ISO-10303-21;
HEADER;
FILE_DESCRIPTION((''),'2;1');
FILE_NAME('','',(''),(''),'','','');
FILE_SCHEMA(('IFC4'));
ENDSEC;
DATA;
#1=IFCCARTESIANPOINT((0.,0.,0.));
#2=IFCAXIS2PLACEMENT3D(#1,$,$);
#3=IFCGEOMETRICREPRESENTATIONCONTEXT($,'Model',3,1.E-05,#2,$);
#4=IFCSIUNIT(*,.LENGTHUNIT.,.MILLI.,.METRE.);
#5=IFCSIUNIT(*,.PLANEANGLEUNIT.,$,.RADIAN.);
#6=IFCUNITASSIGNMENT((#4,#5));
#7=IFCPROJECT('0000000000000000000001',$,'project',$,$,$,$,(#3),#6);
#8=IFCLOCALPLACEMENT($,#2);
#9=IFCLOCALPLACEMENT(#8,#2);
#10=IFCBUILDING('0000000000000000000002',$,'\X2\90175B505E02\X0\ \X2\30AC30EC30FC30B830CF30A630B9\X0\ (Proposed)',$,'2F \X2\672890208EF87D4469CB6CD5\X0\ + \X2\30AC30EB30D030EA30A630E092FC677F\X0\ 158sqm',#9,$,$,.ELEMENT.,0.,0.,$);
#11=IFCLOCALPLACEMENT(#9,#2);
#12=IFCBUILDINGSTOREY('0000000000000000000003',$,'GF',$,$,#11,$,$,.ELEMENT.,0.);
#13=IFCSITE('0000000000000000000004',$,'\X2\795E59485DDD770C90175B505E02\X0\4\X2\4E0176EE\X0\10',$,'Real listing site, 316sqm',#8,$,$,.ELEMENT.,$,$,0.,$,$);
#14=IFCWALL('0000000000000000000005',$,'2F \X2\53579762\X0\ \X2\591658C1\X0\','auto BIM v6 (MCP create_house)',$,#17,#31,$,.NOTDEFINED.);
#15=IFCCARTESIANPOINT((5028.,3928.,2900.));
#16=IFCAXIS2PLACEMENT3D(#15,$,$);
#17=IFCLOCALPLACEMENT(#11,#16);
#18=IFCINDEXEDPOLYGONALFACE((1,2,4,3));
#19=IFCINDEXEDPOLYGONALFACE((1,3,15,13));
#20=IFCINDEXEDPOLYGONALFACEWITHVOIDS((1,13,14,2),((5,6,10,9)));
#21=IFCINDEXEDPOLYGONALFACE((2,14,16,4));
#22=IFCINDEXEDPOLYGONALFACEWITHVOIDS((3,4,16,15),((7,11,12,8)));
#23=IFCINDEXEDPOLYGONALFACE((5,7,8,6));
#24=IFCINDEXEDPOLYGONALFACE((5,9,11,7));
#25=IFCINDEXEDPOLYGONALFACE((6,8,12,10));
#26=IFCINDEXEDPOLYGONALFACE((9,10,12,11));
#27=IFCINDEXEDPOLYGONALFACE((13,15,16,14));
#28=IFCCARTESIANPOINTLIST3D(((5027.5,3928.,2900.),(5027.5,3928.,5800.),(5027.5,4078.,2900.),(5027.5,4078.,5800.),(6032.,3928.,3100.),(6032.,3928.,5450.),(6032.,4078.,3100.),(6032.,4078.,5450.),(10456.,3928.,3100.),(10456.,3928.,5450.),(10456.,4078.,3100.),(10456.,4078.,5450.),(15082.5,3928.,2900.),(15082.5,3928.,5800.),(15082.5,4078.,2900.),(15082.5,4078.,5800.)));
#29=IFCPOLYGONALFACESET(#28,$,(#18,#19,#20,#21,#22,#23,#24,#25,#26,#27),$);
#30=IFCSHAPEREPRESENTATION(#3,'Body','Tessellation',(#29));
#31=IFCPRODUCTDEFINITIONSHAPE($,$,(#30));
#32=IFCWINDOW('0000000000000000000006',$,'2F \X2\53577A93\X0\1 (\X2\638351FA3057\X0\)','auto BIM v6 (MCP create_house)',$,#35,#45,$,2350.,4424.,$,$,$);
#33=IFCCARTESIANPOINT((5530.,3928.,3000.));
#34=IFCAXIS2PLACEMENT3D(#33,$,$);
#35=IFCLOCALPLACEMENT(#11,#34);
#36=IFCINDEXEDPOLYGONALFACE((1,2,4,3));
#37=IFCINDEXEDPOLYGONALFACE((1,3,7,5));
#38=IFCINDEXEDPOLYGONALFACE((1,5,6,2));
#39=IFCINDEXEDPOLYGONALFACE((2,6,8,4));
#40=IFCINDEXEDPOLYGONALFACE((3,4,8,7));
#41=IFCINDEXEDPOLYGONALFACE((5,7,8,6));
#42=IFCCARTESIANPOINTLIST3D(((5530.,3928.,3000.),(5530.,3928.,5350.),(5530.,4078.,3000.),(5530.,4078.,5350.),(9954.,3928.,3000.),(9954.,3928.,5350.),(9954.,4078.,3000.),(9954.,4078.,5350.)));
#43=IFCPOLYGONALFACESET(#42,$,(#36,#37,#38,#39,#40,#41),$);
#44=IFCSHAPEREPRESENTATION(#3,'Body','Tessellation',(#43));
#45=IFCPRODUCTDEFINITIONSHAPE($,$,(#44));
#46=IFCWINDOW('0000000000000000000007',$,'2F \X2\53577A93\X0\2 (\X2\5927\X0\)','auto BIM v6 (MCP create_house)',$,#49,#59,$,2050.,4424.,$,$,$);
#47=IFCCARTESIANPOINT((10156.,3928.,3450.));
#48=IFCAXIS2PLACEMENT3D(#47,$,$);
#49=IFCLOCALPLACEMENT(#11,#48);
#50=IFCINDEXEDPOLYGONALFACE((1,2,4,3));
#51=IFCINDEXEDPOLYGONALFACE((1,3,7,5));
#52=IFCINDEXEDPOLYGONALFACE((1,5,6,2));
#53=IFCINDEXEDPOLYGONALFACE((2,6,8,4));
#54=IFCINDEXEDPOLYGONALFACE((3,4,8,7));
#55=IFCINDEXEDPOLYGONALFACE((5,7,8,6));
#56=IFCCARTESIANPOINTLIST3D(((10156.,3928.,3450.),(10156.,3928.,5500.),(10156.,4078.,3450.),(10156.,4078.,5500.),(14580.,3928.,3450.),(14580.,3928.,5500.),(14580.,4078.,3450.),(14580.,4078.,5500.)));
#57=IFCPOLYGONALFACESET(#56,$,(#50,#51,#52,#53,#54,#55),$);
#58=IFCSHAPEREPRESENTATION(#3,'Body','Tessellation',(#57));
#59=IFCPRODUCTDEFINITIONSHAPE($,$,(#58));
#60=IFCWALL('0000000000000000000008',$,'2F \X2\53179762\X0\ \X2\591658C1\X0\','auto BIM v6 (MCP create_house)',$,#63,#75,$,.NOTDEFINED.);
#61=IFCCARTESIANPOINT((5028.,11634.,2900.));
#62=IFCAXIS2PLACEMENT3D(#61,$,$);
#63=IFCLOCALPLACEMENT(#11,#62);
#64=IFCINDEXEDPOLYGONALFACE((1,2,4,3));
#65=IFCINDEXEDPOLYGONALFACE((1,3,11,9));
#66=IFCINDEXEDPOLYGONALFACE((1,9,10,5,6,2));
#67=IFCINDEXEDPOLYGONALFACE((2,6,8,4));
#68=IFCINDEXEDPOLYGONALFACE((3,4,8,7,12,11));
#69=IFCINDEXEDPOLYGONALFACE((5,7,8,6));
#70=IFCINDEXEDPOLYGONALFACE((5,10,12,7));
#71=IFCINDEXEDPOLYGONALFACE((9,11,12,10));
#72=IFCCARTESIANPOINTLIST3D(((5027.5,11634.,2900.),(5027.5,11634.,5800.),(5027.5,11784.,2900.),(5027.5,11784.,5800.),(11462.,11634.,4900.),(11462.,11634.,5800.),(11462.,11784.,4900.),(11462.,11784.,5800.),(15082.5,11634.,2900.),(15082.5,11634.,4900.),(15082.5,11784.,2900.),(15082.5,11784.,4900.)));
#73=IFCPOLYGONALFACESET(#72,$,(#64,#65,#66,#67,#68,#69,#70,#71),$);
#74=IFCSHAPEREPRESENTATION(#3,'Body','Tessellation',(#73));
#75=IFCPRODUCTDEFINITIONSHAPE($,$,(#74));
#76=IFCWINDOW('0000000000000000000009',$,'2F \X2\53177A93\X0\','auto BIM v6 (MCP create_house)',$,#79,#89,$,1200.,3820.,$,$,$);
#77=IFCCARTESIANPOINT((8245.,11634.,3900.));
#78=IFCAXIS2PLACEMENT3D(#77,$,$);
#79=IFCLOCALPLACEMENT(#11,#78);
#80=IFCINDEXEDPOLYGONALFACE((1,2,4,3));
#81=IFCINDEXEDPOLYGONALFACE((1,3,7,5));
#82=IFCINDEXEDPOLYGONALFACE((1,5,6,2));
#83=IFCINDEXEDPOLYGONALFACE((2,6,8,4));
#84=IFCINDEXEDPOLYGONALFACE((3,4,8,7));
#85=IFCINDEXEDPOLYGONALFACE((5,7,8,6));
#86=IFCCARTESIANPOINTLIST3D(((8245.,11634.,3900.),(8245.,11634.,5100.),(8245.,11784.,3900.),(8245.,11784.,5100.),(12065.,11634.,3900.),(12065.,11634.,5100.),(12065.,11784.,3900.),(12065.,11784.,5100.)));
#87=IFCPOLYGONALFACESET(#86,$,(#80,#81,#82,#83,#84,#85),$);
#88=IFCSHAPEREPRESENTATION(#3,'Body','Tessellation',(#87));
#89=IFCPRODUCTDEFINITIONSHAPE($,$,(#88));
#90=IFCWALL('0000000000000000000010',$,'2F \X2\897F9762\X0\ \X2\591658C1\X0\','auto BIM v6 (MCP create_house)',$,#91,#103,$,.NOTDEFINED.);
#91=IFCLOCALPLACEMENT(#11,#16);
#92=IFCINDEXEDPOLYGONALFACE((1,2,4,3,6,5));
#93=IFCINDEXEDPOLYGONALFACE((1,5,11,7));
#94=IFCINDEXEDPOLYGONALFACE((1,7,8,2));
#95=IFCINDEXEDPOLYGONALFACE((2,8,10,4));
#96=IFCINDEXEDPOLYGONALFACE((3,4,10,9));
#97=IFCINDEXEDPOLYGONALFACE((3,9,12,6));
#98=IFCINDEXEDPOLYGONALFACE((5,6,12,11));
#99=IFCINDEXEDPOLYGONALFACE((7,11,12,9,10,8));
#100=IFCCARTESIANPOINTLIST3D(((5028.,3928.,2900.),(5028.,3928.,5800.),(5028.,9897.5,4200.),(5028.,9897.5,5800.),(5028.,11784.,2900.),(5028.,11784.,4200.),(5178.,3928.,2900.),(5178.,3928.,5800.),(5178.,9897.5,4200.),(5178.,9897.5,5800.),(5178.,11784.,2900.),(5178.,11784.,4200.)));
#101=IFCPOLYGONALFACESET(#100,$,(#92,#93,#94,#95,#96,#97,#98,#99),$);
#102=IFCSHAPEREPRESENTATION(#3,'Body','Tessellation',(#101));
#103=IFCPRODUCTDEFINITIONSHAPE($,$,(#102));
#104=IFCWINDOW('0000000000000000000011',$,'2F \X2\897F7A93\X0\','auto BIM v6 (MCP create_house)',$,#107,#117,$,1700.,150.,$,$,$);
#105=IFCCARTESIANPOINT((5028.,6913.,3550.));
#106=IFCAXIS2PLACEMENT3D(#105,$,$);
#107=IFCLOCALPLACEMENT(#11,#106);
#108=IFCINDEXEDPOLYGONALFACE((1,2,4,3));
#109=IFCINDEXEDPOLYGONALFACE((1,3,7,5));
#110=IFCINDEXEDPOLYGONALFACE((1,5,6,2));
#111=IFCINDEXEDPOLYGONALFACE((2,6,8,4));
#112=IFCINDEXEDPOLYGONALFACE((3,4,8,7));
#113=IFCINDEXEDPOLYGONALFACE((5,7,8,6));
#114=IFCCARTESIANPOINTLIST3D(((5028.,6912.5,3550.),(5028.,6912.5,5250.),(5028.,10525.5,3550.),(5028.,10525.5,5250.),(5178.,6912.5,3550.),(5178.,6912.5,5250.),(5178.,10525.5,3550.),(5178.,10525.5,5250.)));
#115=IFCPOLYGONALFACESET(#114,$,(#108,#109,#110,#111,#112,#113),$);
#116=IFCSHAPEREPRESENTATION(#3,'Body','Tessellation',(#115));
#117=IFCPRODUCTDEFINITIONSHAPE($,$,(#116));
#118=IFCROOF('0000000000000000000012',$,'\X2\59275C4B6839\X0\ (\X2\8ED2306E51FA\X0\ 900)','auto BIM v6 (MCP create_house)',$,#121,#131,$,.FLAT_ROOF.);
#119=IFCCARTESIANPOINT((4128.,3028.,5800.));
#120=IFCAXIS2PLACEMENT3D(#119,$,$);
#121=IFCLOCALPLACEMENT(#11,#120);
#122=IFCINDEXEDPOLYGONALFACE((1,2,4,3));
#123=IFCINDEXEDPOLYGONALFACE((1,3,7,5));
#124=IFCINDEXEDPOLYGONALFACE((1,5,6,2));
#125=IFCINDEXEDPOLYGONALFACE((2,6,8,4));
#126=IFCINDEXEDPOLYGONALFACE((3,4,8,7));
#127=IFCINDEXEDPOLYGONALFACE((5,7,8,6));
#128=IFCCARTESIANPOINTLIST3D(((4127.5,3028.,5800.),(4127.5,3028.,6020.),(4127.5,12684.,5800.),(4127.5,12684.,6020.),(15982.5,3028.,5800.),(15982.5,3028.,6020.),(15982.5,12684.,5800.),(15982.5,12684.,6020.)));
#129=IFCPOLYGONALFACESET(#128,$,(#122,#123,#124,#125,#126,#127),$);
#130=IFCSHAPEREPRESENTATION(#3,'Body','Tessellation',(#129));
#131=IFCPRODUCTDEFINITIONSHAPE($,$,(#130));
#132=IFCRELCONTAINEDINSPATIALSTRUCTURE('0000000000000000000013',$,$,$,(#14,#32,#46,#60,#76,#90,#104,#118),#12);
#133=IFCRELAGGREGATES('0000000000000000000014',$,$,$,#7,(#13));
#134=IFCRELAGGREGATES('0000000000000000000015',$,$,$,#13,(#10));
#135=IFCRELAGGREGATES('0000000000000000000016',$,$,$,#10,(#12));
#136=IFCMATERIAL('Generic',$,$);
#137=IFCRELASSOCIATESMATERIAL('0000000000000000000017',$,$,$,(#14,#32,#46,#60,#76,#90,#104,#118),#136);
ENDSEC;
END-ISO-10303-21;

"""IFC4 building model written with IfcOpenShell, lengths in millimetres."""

from ifc_helpers import new_model, si_unit, frame, frame_2d, origin, place, context, project, spatial, rectangle, extrude, material, element, fill, save


model = new_model("IFC4")

# Units and contexts
model_context = context("Model", 3, precision=1e-05, world=origin())
ifc_project = project(units=[si_unit("LENGTHUNIT", "METRE", prefix="MILLI"), si_unit("PLANEANGLEUNIT", "RADIAN")], contexts=[model_context])

# Site, building, storey
site_placement = place(None, origin())
site = spatial("IfcSite", under=ifc_project, at=site_placement, Name="神奈川県逗子市4丁目10", ObjectType="Real listing site, 316sqm", CompositionType="ELEMENT", RefElevation=0.0)
building_placement = place(site_placement, origin())
building = spatial("IfcBuilding", under=site, at=building_placement, Name="逗子市 ガレージハウス (Proposed)", ObjectType="2F 木造軸組構法 + ガルバリウム鋼板 158sqm", CompositionType="ELEMENT", ElevationOfRefHeight=0.0, ElevationOfTerrain=0.0)
storey_placement = place(building_placement, origin())
storey = spatial("IfcBuildingStorey", under=building, at=storey_placement, Name="GF", CompositionType="ELEMENT", Elevation=0.0)

# Shared definitions
ifc_material = material(Name="Generic")

# Wall, openings, windows
wall_1_placement = place(storey_placement, frame((5028.0, 3928.0, 2900.0)))
wall_1 = element("IfcWall", 1, at=wall_1_placement, inside=storey, material=ifc_material, Name="2F 南面 外壁", Description="auto BIM v6 (MCP create_house)", PredefinedType="NOTDEFINED", context=model_context, shape_type="SweptSolid", body=[
    extrude(rectangle(XDim=10055.0, YDim=150.0, at=frame_2d((5027.0, 75.0))), frame((5028.0, 3928.0, 2900.0)), (0.0, 0.0, 1.0), 2900.0),
])
opening_1_placement = place(storey_placement, frame((5530.0, 3928.0, 3000.0)))
opening_1 = element("IfcOpeningElement", 2, at=opening_1_placement, cuts=wall_1, PredefinedType="NOTDEFINED", context=model_context, shape_type="SweptSolid", body=[
    extrude(rectangle(XDim=4424.0, YDim=150.0, at=frame_2d((2212.0, 75.0))), frame((5530.0, 3928.0, 3000.0)), (0.0, 0.0, 1.0), 2350.0),
])
opening_2_placement = place(storey_placement, frame((10156.0, 3928.0, 3450.0)))
opening_2 = element("IfcOpeningElement", 3, at=opening_2_placement, cuts=wall_1, PredefinedType="NOTDEFINED", context=model_context, shape_type="SweptSolid", body=[
    extrude(rectangle(XDim=4424.0, YDim=150.0, at=frame_2d((2212.0, 75.0))), frame((10156.0, 3928.0, 3450.0)), (0.0, 0.0, 1.0), 2050.0),
])
window_1_placement = place(storey_placement, frame((5530.0, 3928.0, 3000.0)))
window_1 = element("IfcWindow", 4, at=window_1_placement, inside=storey, material=ifc_material, Name="2F 南窓1 (掃出し)", Description="auto BIM v6 (MCP create_house)", OverallHeight=2350.0, OverallWidth=4424.0, context=model_context, shape_type="SweptSolid", body=[
    extrude(rectangle(XDim=4424.0, YDim=150.0, at=frame_2d((2212.0, 75.0))), frame((5530.0, 3928.0, 3000.0)), (0.0, 0.0, 1.0), 2350.0),
])
fill(opening_1, window_1)
window_2_placement = place(storey_placement, frame((10156.0, 3928.0, 3450.0)))
window_2 = element("IfcWindow", 5, at=window_2_placement, inside=storey, material=ifc_material, Name="2F 南窓2 (大)", Description="auto BIM v6 (MCP create_house)", OverallHeight=2050.0, OverallWidth=4424.0, context=model_context, shape_type="SweptSolid", body=[
    extrude(rectangle(XDim=4424.0, YDim=150.0, at=frame_2d((2212.0, 75.0))), frame((10156.0, 3928.0, 3450.0)), (0.0, 0.0, 1.0), 2050.0),
])
fill(opening_2, window_2)

# Walls, openings, windows
wall_2_placement = place(storey_placement, frame((5028.0, 11634.0, 2900.0)))
wall_2 = element("IfcWall", 6, at=wall_2_placement, inside=storey, material=ifc_material, Name="2F 北面 外壁", Description="auto BIM v6 (MCP create_house)", PredefinedType="NOTDEFINED", context=model_context, shape_type="SweptSolid", body=[
    extrude(rectangle(XDim=10055.0, YDim=150.0, at=frame_2d((5027.0, 75.0))), frame((5028.0, 11634.0, 2900.0)), (0.0, 0.0, 1.0), 2900.0),
])
opening_3_placement = place(storey_placement, frame((8245.0, 11634.0, 3900.0)))
opening_3 = element("IfcOpeningElement", 7, at=opening_3_placement, cuts=wall_2, PredefinedType="NOTDEFINED", context=model_context, shape_type="SweptSolid", body=[
    extrude(rectangle(XDim=3820.0, YDim=150.0, at=frame_2d((1910.0, 75.0))), frame((8245.0, 11634.0, 3900.0)), (0.0, 0.0, 1.0), 1200.0),
])
window_3_placement = place(storey_placement, frame((8245.0, 11634.0, 3900.0)))
window_3 = element("IfcWindow", 8, at=window_3_placement, inside=storey, material=ifc_material, Name="2F 北窓", Description="auto BIM v6 (MCP create_house)", OverallHeight=1200.0, OverallWidth=3820.0, context=model_context, shape_type="SweptSolid", body=[
    extrude(rectangle(XDim=3820.0, YDim=150.0, at=frame_2d((1910.0, 75.0))), frame((8245.0, 11634.0, 3900.0)), (0.0, 0.0, 1.0), 1200.0),
])
fill(opening_3, window_3)
wall_3_placement = place(storey_placement, frame((5028.0, 3928.0, 2900.0)))
wall_3 = element("IfcWall", 9, at=wall_3_placement, inside=storey, material=ifc_material, Name="2F 西面 外壁", Description="auto BIM v6 (MCP create_house)", PredefinedType="NOTDEFINED", context=model_context, shape_type="SweptSolid", body=[
    extrude(rectangle(XDim=150.0, YDim=7856.0, at=frame_2d((75.0, 3928.0))), frame((5028.0, 3928.0, 2900.0)), (0.0, 0.0, 1.0), 2900.0),
])
opening_4_placement = place(storey_placement, frame((5028.0, 6913.0, 3550.0)))
opening_4 = element("IfcOpeningElement", 10, at=opening_4_placement, cuts=wall_3, PredefinedType="NOTDEFINED", context=model_context, shape_type="SweptSolid", body=[
    extrude(rectangle(XDim=150.0, YDim=3613.0, at=frame_2d((75.0, 1806.0))), frame((5028.0, 6913.0, 3550.0)), (0.0, 0.0, 1.0), 1700.0),
])
window_4_placement = place(storey_placement, frame((5028.0, 6913.0, 3550.0)))
window_4 = element("IfcWindow", 11, at=window_4_placement, inside=storey, material=ifc_material, Name="2F 西窓", Description="auto BIM v6 (MCP create_house)", OverallHeight=1700.0, OverallWidth=150.0, context=model_context, shape_type="SweptSolid", body=[
    extrude(rectangle(XDim=150.0, YDim=3613.0, at=frame_2d((75.0, 1806.0))), frame((5028.0, 6913.0, 3550.0)), (0.0, 0.0, 1.0), 1700.0),
])
fill(opening_4, window_4)

# Roof
roof_placement = place(storey_placement, frame((4128.0, 3028.0, 5800.0)))
element("IfcRoof", 12, at=roof_placement, inside=storey, material=ifc_material, Name="大屋根 (軒の出 900)", Description="auto BIM v6 (MCP create_house)", PredefinedType="FLAT_ROOF", context=model_context, shape_type="SweptSolid", body=[
    extrude(rectangle(XDim=11855.0, YDim=9656.0, at=frame_2d((5927.0, 4828.0))), frame((4128.0, 3028.0, 5800.0)), (0.0, 0.0, 1.0), 220.0),
])

save(model, "model.ifc")
